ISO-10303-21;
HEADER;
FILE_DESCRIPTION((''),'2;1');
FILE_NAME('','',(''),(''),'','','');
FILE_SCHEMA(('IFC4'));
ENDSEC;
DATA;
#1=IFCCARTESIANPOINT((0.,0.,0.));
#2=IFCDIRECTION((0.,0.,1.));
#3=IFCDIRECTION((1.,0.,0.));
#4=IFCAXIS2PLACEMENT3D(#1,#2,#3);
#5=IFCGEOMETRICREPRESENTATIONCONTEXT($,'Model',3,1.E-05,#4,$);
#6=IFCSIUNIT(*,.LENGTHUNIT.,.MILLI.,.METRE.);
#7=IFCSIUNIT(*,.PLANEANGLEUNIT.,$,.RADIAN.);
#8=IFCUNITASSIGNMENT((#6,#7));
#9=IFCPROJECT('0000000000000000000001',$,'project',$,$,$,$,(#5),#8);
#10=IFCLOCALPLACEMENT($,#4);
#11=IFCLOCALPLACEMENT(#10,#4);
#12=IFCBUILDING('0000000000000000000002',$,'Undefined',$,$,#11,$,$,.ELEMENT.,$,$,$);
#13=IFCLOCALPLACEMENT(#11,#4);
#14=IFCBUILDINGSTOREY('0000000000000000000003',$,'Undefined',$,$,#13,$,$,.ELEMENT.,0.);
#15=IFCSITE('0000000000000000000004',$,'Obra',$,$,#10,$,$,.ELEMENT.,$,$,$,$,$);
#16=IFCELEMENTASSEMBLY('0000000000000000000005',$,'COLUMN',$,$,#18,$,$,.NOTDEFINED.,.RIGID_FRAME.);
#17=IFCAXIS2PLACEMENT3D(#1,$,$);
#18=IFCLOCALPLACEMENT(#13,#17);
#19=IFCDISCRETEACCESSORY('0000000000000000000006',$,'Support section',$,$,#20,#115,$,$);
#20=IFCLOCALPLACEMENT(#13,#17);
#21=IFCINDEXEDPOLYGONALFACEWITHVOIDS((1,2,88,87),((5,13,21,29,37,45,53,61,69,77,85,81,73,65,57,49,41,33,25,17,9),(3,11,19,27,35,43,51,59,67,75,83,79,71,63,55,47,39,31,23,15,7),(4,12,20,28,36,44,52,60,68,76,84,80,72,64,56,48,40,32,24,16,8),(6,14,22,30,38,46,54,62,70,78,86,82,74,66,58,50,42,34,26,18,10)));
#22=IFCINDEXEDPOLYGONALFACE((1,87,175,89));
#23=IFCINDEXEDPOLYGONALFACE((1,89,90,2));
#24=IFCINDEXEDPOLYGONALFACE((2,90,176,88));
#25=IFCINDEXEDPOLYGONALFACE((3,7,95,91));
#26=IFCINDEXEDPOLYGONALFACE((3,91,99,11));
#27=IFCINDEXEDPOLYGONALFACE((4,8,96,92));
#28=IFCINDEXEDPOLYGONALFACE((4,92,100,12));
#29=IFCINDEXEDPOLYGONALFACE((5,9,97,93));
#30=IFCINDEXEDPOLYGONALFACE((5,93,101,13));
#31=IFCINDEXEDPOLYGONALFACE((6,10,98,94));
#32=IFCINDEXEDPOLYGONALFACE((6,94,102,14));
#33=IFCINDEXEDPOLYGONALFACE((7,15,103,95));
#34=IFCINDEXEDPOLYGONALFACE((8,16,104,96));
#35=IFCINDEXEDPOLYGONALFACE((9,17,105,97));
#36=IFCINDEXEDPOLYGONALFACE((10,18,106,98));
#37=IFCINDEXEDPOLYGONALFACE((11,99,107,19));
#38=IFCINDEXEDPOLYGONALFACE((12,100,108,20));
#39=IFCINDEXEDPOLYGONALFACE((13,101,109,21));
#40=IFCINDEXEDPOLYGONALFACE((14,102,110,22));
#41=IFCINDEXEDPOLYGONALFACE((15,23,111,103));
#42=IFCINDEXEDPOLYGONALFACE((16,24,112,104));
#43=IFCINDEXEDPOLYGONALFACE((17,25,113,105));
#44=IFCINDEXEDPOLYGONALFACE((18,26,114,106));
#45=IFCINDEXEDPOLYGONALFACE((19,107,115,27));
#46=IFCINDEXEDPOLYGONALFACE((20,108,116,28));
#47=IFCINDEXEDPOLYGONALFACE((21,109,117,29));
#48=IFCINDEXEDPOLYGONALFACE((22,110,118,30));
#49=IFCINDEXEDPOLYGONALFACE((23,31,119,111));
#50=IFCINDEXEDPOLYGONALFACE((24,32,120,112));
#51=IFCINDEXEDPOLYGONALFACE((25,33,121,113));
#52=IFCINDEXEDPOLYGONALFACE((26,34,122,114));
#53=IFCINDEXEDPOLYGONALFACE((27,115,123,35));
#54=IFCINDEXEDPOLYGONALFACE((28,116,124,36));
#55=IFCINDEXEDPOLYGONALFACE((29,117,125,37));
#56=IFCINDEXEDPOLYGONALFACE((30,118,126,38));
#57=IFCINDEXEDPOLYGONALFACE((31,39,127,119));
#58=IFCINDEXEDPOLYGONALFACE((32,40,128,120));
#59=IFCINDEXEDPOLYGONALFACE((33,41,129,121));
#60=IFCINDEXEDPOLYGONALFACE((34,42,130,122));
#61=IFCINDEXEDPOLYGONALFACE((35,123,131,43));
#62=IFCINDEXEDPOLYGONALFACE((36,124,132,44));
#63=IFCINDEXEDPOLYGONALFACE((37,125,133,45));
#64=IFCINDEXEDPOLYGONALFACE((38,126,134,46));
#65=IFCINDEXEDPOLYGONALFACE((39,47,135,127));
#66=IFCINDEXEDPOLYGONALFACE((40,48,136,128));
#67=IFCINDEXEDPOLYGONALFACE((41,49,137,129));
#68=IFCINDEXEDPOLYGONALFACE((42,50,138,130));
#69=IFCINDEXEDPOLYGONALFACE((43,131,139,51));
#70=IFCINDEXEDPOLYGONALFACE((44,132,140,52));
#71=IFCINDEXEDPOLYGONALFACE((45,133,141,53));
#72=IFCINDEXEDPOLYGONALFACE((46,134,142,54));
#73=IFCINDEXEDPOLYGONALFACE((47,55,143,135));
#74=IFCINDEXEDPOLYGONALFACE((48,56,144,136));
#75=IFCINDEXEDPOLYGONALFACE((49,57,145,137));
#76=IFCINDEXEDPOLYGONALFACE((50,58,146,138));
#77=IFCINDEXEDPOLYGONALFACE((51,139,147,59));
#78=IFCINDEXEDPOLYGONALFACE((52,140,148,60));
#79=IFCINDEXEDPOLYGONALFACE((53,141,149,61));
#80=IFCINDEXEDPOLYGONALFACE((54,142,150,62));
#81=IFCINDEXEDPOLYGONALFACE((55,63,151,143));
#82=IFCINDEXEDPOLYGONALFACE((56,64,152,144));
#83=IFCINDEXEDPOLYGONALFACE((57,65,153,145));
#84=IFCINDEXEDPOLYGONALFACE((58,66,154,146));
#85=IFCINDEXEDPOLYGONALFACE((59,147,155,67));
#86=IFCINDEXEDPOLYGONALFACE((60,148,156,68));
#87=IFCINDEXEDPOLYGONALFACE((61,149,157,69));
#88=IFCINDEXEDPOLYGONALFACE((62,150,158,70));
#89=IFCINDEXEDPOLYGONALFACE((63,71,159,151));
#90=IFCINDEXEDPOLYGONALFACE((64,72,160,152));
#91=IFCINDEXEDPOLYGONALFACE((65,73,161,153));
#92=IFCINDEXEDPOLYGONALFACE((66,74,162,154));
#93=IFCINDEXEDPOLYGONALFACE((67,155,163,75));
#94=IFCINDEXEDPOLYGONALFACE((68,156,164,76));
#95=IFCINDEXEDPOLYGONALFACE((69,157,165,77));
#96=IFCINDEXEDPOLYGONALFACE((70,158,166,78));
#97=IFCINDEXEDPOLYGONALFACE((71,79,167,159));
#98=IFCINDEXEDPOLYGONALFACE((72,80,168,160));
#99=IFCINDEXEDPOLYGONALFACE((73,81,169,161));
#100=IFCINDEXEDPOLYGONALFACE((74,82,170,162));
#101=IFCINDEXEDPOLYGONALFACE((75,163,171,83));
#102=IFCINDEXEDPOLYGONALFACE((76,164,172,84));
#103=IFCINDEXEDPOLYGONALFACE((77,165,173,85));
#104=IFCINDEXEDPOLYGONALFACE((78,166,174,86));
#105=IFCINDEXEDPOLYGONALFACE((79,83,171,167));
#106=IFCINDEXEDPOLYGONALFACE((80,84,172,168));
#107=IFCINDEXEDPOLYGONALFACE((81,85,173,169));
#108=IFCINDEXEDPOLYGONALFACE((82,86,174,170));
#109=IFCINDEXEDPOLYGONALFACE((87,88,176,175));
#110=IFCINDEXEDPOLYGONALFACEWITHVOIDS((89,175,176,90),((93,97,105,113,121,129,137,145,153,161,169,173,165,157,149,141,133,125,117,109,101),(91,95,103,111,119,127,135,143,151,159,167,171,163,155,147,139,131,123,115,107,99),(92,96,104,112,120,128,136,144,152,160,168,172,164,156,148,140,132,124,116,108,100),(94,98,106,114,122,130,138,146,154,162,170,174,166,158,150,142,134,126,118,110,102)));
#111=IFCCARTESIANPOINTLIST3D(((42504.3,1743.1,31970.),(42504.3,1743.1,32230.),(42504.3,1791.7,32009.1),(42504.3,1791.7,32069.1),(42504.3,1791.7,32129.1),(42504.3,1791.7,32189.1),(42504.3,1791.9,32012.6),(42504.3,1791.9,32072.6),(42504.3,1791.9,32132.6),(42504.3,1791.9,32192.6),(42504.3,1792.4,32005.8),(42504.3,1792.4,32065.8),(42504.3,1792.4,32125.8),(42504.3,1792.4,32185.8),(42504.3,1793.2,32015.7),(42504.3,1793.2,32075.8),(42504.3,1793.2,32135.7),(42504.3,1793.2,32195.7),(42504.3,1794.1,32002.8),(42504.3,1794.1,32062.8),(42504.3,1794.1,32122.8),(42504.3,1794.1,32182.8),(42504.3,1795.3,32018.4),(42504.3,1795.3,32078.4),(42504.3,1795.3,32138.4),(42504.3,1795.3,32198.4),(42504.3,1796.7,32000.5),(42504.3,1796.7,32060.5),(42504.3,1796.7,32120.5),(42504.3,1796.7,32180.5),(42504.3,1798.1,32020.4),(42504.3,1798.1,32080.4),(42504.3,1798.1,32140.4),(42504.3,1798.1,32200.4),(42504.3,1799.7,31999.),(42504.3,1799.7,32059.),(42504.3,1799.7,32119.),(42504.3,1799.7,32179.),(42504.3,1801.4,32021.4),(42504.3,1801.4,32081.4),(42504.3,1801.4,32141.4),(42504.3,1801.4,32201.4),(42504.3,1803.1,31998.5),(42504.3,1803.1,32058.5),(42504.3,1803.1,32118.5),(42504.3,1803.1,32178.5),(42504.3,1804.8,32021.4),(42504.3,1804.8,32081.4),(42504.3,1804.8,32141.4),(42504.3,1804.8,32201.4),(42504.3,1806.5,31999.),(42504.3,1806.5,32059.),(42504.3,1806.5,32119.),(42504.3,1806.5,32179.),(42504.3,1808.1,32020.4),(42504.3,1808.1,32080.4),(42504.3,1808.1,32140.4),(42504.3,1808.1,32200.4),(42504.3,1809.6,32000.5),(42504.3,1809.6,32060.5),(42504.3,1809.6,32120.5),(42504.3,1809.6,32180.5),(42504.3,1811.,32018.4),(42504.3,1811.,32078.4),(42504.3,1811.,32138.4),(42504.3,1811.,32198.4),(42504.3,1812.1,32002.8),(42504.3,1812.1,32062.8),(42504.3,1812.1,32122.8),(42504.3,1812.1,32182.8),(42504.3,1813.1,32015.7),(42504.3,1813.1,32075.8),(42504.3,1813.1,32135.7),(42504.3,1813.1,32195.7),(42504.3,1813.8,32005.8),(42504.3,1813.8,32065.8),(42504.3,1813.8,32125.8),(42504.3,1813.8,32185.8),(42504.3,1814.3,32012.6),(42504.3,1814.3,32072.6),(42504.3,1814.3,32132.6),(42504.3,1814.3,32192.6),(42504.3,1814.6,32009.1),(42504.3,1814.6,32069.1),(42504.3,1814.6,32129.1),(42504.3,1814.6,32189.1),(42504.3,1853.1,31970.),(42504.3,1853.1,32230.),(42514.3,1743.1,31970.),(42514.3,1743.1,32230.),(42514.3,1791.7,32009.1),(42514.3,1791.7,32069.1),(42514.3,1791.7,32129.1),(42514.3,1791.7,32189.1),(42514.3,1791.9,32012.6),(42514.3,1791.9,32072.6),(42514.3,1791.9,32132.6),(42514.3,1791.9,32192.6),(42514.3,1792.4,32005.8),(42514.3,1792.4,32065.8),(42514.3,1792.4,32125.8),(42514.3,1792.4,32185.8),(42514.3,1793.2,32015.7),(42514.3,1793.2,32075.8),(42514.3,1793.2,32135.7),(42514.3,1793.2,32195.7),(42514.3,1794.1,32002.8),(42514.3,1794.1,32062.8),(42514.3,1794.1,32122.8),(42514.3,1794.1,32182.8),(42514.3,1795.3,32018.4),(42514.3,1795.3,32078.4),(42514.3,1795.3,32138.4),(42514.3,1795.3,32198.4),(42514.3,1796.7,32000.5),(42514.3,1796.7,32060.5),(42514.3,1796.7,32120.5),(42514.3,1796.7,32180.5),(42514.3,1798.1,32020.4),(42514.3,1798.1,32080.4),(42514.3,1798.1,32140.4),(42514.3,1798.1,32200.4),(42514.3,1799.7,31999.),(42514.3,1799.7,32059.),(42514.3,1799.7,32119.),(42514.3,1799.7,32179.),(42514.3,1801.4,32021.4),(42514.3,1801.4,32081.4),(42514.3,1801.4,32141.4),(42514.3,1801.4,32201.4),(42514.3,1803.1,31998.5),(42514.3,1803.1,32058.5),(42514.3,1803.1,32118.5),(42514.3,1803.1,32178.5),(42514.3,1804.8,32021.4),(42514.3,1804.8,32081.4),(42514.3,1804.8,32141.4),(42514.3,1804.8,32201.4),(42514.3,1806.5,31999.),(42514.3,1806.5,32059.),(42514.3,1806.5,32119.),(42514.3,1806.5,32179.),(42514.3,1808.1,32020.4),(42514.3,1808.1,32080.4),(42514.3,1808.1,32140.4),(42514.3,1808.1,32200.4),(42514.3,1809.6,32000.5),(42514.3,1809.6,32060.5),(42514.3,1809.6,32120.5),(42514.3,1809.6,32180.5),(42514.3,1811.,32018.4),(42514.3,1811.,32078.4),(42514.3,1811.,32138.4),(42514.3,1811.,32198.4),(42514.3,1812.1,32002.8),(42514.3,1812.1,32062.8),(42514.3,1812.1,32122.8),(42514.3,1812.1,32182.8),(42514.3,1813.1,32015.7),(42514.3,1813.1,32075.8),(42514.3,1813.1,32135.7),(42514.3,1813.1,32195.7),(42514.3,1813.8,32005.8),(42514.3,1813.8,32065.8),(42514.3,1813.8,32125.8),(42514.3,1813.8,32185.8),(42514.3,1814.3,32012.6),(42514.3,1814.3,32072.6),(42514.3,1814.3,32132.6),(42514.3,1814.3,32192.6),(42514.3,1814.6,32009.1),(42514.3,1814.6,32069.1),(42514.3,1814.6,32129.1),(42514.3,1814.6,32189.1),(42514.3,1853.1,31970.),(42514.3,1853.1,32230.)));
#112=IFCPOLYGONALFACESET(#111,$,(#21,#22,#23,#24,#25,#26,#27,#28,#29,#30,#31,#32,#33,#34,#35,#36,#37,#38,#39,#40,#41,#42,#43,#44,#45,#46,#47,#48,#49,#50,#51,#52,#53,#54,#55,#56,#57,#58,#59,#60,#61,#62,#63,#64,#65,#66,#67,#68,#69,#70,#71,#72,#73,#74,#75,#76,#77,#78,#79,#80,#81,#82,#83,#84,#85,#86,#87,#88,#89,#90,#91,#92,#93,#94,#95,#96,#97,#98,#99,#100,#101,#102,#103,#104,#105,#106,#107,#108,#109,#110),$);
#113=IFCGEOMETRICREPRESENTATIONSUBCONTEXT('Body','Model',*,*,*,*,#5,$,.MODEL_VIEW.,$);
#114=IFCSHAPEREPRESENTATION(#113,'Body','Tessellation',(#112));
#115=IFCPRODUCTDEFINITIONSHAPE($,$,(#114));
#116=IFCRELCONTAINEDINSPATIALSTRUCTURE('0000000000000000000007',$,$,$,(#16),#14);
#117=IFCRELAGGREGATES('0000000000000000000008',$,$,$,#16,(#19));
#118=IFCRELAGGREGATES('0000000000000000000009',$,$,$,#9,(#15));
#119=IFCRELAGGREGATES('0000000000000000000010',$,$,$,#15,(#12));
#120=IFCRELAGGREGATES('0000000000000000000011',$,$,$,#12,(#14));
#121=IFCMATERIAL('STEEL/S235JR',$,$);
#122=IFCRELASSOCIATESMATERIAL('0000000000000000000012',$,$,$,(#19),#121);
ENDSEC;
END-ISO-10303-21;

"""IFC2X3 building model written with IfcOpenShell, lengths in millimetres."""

from ifc_helpers import new_model, si_unit, frame, origin_with_axes, origin_2d_with_axis, place, context, subcontext, project, spatial, rectangle, circle, extrude, source, transform, mapped, material, element, aggregate, save


model = new_model("IFC2X3")

# Units and contexts
model_context = context("Model", 3, precision=1e-05, world=origin_with_axes())
body_context = subcontext(model_context, "Body", "Model", "MODEL_VIEW")
ifc_project = project(units=[si_unit("LENGTHUNIT", "METRE", prefix="MILLI"), si_unit("PLANEANGLEUNIT", "RADIAN")], contexts=[model_context])

# Site, building, storey
site_placement = place(None, origin_with_axes())
site = spatial("IfcSite", under=ifc_project, at=site_placement, Name="Obra", CompositionType="ELEMENT")
building_placement = place(site_placement, origin_with_axes())
building = spatial("IfcBuilding", under=site, at=building_placement, Name="Undefined", CompositionType="ELEMENT")
storey_placement = place(building_placement, origin_with_axes())
storey = spatial("IfcBuildingStorey", under=building, at=storey_placement, Name="Undefined", CompositionType="ELEMENT", Elevation=0.0)

# Shared definitions
ifc_material_1 = material(Name="STEEL/S235JR")

# Element assembly, discrete accessory, opening
assembly_1_placement = place(storey_placement, origin_with_axes())
assembly_1 = element("IfcElementAssembly", 1, at=assembly_1_placement, inside=storey, Name="COLUMN", AssemblyPlace="NOTDEFINED", PredefinedType="RIGID_FRAME")
discrete_accessory_1_placement = place(assembly_1_placement, frame((42509.3, 1798.1, 31970.0), z_axis=(0.0, 0.0, 1.0), x_axis=(0.0, -1.0, 0.0)))
discrete_accessory_1 = element("IfcDiscreteAccessory", 2, at=discrete_accessory_1_placement, material=ifc_material_1, Name="Support section", context=body_context, shape_type="SweptSolid", body=[
    extrude(rectangle(XDim=10.0, YDim=110.0, at=origin_2d_with_axis()), frame((0.0, 0.0, 260.0), z_axis=(0.0, 0.0, -1.0), x_axis=(0.0, 1.0, 0.0)), (0.0, 0.0, 1.0), 260.0),
])
shared_shape_1 = source(origin_with_axes(), body_context, "Body", "SweptSolid", [
    extrude(circle(Radius=11.5, at=origin_2d_with_axis()), frame((0.0, -14.4, 0.0), z_axis=(0.0, 1.0, 0.0), x_axis=(1.0, 0.0, 0.0)), (0.0, 0.0, 1.0), 10.2),
])
opening_1_placement = place(assembly_1_placement, frame((42500.0, 1753.1, 32300.0), z_axis=(0.0, 1.0, 0.0), x_axis=(0.0, 0.0, -1.0)))
element("IfcOpeningElement", 3, at=opening_1_placement, cuts=discrete_accessory_1, ObjectType="Opening", context=body_context, shape_type="MappedRepresentation", body=[
    mapped(shared_shape_1, transform((110.0, 0.0, 50.0))),
    mapped(shared_shape_1, transform((170.0, 0.0, 50.0))),
    mapped(shared_shape_1, transform((230.0, 0.0, 50.0))),
    mapped(shared_shape_1, transform((290.0, 0.0, 50.0))),
])
aggregate(assembly_1, [discrete_accessory_1])

save(model, "model.ifc")
